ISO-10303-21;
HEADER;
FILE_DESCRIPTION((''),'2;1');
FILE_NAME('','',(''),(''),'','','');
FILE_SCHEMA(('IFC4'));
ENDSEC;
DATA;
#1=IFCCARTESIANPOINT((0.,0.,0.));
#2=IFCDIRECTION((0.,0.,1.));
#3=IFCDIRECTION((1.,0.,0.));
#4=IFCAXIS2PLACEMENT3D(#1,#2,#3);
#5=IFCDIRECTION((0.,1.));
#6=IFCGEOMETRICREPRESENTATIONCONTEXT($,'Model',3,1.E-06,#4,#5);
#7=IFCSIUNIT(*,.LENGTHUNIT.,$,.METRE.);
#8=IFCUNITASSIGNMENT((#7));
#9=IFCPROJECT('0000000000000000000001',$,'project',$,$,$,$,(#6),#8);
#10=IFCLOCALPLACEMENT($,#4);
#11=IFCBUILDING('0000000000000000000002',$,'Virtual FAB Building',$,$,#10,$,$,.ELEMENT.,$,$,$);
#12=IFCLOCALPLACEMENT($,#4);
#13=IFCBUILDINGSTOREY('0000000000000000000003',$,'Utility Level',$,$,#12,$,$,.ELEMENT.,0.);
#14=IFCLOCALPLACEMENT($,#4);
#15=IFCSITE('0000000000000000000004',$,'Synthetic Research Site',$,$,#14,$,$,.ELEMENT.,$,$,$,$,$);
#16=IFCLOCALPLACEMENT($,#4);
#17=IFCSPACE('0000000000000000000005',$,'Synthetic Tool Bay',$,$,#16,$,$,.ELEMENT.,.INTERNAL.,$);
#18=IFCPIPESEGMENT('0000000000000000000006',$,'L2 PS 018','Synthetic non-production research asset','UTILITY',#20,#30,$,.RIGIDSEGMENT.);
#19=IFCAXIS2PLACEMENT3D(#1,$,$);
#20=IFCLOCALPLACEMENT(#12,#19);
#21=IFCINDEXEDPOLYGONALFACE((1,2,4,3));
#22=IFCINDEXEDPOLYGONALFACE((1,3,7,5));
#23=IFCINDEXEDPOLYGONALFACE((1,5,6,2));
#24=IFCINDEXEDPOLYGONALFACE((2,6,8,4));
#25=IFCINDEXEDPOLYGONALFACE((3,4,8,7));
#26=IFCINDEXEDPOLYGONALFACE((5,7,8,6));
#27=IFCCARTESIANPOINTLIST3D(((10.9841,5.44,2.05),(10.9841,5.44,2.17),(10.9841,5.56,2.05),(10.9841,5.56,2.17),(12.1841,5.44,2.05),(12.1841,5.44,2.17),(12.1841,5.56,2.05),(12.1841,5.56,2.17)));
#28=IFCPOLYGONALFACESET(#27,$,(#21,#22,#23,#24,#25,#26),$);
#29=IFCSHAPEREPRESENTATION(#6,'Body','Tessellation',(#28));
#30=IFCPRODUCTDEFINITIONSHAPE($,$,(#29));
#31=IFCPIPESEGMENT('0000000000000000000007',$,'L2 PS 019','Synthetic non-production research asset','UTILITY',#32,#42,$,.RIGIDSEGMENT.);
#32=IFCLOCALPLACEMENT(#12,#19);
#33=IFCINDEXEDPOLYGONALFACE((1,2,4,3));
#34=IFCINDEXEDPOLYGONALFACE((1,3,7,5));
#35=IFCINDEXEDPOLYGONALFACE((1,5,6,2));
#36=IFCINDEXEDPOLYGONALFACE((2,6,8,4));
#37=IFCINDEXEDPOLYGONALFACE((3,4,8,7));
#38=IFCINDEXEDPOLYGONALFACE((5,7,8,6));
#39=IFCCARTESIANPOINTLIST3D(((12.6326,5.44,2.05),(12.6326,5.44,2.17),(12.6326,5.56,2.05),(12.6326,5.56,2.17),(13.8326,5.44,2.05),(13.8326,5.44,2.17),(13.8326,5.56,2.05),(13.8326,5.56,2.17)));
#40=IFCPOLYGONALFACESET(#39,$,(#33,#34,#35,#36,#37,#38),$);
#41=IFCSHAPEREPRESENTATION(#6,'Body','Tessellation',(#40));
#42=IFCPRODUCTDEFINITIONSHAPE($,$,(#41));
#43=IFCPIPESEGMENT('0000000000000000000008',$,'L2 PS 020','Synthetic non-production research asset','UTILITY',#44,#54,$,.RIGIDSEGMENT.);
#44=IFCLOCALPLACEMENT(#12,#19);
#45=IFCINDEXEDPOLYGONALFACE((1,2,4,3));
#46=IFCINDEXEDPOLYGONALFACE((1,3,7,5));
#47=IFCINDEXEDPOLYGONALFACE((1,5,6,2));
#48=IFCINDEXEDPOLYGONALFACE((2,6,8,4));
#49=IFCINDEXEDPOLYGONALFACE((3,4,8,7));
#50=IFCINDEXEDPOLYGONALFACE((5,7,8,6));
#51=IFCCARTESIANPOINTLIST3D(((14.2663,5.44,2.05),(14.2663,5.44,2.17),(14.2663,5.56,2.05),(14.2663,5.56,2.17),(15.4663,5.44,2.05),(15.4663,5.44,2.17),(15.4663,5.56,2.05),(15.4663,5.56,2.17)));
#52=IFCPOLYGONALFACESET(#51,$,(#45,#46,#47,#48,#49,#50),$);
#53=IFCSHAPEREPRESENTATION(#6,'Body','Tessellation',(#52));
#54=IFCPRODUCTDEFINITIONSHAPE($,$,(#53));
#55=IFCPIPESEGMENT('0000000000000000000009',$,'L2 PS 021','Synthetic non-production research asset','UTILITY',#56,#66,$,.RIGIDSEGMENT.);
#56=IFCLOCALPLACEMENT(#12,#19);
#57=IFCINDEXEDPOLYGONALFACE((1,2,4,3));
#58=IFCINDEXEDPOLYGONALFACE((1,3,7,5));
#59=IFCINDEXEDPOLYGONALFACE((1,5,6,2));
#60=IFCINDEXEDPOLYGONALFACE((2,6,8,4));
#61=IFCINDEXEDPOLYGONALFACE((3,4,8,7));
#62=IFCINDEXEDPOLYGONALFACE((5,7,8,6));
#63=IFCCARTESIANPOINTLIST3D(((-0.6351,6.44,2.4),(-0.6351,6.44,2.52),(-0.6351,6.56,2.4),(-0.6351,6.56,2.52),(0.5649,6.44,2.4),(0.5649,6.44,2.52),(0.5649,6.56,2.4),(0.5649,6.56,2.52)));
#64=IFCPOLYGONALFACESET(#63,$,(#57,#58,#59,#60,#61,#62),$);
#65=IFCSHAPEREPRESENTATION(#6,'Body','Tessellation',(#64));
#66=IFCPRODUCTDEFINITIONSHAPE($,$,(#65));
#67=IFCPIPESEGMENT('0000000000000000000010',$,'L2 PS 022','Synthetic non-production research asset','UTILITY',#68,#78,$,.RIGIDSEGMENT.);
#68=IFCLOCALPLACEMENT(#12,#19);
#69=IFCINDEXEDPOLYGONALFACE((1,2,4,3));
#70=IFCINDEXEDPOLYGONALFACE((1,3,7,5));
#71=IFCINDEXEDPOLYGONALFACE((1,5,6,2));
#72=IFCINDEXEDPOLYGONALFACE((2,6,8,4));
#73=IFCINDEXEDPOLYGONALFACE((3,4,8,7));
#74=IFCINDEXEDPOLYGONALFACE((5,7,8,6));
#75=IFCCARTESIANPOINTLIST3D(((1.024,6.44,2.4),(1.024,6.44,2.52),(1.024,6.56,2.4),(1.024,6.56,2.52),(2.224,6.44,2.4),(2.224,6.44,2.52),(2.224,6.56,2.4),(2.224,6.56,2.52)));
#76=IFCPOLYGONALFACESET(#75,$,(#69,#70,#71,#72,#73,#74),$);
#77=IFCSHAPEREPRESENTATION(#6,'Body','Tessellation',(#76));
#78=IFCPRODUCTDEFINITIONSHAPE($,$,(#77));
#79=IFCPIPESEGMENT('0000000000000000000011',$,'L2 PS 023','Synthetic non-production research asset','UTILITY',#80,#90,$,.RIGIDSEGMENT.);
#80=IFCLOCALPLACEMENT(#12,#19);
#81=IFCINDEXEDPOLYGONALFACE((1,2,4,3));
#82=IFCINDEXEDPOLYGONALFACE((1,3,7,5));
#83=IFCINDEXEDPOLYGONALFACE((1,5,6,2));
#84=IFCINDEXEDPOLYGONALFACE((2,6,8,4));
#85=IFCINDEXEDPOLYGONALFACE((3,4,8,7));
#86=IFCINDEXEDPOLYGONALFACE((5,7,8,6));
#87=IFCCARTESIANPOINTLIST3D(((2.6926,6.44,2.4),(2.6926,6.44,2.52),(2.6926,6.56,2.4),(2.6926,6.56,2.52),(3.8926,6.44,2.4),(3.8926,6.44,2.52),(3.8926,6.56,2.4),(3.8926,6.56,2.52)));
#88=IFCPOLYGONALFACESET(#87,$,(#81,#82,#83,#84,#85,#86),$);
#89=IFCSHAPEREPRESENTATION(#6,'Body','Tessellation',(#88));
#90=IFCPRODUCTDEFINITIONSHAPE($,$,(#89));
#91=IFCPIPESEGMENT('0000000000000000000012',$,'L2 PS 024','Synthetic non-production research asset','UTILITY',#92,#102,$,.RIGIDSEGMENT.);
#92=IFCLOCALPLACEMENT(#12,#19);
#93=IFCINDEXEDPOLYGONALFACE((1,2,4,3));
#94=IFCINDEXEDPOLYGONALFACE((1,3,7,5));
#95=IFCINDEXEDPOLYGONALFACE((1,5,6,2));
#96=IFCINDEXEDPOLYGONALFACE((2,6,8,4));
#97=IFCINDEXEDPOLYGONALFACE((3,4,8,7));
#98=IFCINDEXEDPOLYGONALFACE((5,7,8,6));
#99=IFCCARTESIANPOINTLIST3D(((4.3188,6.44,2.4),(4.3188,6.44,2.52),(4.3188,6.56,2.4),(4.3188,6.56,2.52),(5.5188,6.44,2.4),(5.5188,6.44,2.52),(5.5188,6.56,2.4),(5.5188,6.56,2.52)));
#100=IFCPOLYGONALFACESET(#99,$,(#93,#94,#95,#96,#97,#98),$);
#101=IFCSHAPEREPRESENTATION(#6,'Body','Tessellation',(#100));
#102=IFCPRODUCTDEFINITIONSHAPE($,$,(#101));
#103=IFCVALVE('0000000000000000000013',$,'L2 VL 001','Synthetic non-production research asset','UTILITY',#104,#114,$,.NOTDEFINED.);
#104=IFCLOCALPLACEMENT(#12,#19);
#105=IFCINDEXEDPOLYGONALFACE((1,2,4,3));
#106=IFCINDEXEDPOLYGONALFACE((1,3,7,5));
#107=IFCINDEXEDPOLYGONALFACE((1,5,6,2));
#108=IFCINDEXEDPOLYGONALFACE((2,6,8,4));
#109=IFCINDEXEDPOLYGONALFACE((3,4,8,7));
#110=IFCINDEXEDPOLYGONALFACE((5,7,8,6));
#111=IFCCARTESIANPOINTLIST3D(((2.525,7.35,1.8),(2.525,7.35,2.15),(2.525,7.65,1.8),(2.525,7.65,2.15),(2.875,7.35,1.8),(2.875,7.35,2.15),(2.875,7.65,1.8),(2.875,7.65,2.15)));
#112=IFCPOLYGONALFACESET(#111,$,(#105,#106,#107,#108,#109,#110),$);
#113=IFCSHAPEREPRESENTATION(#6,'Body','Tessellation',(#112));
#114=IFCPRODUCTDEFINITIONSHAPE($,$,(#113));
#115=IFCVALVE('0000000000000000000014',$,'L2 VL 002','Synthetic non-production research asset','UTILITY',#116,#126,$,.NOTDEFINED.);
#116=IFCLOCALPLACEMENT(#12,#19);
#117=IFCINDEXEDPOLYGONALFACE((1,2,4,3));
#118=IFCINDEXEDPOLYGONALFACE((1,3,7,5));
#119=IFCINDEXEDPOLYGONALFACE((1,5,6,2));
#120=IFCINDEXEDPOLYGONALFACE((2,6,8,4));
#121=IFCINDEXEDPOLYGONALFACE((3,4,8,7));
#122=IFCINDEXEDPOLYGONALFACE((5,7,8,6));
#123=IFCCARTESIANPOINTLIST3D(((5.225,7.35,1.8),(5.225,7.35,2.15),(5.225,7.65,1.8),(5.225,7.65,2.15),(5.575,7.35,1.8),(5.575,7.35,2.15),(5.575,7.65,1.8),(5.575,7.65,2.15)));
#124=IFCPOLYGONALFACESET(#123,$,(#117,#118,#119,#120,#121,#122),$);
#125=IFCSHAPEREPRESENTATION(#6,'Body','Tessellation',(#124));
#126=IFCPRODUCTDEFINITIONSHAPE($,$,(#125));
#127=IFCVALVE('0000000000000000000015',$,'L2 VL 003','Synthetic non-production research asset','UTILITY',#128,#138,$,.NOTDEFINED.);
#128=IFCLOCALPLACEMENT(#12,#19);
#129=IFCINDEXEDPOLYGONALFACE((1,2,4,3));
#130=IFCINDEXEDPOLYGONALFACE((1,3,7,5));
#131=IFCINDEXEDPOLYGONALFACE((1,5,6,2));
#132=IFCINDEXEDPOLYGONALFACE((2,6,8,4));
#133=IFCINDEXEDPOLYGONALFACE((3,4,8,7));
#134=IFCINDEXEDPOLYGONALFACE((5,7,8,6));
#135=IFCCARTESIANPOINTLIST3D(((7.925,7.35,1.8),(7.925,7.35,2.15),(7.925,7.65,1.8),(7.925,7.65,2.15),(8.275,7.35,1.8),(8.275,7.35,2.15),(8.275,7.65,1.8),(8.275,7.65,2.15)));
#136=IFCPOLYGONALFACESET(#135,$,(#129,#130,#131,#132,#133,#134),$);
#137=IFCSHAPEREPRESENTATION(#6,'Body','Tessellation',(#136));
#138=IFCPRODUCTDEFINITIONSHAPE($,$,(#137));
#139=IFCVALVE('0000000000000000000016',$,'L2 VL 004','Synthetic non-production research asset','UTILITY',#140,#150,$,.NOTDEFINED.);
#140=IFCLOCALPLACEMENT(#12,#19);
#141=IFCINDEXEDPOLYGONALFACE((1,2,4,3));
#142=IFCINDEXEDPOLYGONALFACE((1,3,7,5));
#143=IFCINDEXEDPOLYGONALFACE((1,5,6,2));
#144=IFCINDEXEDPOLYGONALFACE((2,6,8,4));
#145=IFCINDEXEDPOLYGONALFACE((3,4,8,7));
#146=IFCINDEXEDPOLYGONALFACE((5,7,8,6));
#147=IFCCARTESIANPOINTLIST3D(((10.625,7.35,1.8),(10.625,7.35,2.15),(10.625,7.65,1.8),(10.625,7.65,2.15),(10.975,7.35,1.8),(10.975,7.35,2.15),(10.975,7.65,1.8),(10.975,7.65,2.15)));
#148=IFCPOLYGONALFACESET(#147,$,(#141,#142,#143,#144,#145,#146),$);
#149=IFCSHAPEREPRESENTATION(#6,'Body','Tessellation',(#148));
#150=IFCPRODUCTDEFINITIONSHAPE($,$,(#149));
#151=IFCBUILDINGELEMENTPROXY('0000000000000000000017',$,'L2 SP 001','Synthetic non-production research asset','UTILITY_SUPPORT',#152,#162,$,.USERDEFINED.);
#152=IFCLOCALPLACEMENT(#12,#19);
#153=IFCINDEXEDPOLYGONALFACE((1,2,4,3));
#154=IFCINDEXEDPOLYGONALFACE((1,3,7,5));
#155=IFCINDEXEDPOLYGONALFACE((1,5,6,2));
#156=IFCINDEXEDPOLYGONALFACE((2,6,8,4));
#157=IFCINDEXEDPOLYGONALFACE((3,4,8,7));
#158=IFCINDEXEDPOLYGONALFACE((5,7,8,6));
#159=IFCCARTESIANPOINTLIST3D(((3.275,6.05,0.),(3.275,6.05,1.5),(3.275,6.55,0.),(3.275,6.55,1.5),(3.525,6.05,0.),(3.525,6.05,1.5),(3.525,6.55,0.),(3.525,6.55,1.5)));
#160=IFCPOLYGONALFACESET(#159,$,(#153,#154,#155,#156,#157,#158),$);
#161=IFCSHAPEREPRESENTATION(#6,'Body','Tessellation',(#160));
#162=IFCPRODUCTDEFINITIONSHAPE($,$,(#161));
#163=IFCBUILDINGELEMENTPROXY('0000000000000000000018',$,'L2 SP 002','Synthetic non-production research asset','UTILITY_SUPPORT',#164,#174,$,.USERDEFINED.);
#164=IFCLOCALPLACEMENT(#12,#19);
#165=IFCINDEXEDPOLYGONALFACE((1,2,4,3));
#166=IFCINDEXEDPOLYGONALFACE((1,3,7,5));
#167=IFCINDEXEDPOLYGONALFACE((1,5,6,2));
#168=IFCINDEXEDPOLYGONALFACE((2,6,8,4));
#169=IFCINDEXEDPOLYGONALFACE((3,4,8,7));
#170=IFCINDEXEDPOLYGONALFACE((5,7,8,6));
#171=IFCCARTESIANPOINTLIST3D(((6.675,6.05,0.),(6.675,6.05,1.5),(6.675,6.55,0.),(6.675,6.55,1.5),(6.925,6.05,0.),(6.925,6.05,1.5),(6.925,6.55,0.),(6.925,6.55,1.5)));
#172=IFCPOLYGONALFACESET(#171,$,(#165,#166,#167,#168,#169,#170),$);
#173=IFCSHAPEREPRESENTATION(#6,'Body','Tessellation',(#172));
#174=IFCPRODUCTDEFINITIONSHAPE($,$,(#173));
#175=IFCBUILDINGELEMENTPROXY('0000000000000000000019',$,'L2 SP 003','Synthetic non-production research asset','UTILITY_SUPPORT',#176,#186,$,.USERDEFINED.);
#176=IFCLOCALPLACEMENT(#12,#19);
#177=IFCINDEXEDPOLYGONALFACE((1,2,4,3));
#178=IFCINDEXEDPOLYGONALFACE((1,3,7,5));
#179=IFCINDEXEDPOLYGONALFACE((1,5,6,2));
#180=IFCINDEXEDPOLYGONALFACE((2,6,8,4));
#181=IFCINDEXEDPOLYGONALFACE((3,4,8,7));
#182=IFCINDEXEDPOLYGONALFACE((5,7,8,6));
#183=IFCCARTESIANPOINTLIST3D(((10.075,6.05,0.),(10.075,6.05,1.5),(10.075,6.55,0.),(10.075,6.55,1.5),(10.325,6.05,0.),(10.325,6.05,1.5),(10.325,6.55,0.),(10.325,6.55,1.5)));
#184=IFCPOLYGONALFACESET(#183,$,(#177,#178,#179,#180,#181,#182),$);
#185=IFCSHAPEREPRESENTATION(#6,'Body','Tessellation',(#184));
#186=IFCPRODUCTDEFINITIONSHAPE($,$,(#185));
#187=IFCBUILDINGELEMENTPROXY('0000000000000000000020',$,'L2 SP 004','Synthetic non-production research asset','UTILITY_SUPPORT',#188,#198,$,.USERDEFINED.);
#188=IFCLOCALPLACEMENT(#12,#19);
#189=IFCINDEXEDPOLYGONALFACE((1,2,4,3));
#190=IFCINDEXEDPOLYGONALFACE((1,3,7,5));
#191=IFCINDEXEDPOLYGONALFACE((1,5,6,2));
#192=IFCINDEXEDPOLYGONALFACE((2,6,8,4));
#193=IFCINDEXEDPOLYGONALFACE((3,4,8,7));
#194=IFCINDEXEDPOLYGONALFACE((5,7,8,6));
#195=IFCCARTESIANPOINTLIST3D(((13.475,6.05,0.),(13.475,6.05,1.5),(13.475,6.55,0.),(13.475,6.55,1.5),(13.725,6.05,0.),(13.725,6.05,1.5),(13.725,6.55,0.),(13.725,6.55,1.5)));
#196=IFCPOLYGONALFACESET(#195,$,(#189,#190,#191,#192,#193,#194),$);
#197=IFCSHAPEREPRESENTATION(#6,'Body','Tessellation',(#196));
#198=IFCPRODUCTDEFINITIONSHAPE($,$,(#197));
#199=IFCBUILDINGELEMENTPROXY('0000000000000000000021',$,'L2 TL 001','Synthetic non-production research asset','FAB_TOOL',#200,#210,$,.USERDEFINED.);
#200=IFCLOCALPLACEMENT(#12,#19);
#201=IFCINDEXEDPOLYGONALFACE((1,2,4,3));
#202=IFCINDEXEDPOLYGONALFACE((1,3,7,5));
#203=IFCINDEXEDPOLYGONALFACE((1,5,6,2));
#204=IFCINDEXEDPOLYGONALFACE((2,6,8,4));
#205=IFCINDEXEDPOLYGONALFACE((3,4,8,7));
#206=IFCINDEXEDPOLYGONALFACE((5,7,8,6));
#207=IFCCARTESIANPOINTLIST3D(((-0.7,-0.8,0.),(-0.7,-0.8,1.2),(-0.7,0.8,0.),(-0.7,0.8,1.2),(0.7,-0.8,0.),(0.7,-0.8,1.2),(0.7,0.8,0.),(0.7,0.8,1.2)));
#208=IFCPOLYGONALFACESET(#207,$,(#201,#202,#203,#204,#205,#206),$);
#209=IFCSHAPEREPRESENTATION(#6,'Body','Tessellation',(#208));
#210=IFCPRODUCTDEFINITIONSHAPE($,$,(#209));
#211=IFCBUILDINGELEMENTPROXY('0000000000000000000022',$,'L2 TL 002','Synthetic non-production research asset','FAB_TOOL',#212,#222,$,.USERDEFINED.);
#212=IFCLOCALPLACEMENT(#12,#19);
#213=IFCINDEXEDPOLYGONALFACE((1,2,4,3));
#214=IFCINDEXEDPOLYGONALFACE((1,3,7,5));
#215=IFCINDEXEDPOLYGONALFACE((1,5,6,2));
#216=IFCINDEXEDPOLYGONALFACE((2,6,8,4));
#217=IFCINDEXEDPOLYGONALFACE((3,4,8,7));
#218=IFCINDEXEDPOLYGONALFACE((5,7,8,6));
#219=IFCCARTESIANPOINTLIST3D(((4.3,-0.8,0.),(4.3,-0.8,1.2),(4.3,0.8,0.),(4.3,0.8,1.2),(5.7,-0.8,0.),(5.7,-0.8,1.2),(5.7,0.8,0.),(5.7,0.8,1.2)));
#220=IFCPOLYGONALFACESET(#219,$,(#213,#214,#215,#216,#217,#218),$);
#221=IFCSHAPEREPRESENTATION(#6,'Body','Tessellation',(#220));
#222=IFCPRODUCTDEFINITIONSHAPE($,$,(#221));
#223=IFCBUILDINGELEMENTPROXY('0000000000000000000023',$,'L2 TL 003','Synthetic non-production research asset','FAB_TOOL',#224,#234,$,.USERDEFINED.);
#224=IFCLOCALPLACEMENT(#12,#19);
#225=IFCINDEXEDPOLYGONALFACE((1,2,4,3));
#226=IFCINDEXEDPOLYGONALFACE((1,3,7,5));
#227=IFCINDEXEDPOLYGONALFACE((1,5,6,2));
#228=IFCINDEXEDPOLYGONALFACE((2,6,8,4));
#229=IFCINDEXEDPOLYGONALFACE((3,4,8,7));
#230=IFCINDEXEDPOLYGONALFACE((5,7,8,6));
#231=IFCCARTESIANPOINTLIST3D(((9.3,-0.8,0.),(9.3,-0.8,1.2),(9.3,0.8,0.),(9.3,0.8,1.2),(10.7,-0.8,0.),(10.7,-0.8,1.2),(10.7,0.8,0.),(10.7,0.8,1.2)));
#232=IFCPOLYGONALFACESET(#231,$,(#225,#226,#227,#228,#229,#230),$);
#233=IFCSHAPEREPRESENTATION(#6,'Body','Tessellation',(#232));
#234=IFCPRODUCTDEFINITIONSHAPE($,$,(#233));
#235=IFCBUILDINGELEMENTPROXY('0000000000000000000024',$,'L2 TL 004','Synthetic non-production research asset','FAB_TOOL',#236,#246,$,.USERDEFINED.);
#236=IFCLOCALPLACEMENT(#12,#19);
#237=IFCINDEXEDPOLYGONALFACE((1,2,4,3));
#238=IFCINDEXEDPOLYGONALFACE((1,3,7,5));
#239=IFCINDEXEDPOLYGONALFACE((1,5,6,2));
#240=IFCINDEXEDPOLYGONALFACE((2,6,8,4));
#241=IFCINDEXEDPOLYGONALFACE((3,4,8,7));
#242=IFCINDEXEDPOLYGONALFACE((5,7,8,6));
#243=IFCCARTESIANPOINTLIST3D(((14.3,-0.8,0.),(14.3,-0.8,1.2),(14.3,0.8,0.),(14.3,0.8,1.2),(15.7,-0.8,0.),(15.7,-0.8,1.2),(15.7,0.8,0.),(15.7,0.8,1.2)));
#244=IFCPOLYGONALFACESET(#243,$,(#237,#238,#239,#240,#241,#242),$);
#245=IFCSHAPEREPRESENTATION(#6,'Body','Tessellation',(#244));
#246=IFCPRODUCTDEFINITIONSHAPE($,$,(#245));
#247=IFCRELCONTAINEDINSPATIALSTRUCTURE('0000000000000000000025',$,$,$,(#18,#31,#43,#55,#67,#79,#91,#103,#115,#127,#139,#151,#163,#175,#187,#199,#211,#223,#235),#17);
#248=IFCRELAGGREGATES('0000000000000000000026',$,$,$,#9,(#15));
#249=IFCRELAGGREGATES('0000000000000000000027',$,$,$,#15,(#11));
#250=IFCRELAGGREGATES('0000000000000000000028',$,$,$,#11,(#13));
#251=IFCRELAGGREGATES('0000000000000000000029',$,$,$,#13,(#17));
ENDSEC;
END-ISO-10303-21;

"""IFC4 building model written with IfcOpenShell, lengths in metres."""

from ifc_helpers import new_model, si_unit, direction, frame, origin_with_axes, origin_2d_with_axis, place, context, project, spatial, rectangle, extrude, element, save


model = new_model("IFC4")

# Units and contexts
model_context = context("Model", 3, precision=1e-06, world=origin_with_axes(), true_north=direction((0.0, 1.0)))
ifc_project = project(units=[si_unit("LENGTHUNIT", "METRE")], contexts=[model_context])

# Site, building, storey, space
site_placement = place(None, origin_with_axes())
site = spatial("IfcSite", under=ifc_project, at=site_placement, Name="Synthetic Research Site", CompositionType="ELEMENT")
building_placement = place(None, origin_with_axes())
building = spatial("IfcBuilding", under=site, at=building_placement, Name="Virtual FAB Building", CompositionType="ELEMENT")
storey_placement = place(None, origin_with_axes())
storey = spatial("IfcBuildingStorey", under=building, at=storey_placement, Name="Utility Level", CompositionType="ELEMENT", Elevation=0.0)
space_placement = place(None, origin_with_axes())
space = spatial("IfcSpace", under=storey, at=space_placement, Name="Synthetic Tool Bay", CompositionType="ELEMENT", PredefinedType="INTERNAL")

# Pipe segments
for number, where, z_axis, x_axis, name in (
    (1, (11.5841, 5.5, 2.05), (0.0, 0.0, 1.0), (1.0, 0.0, 0.0), "L2 PS 018"),
    (2, (13.2326, 5.5, 2.05), (0.0, 0.0, 1.0), (1.0, 0.0, 0.0), "L2 PS 019"),
    (3, (14.8663, 5.5, 2.05), (0.0, 0.0, 1.0), (1.0, 0.0, 0.0), "L2 PS 020"),
    (4, (-0.0351, 6.5, 2.4), (0.0, 0.0, 1.0), (1.0, 0.0, 0.0), "L2 PS 021"),
    (5, (1.624, 6.5, 2.4), (0.0, 0.0, 1.0), (1.0, 0.0, 0.0), "L2 PS 022"),
    (6, (3.2926, 6.5, 2.4), (0.0, 0.0, 1.0), (1.0, 0.0, 0.0), "L2 PS 023"),
    (7, (4.9188, 6.5, 2.4), (0.0, 0.0, 1.0), (1.0, 0.0, 0.0), "L2 PS 024"),
):
    element("IfcPipeSegment", number, at=place(None, frame(where, z_axis=z_axis, x_axis=x_axis)), inside=space, Name=name, Description="Synthetic non-production research asset", ObjectType="UTILITY", PredefinedType="RIGIDSEGMENT", context=model_context, shape_type="SweptSolid", body=[
        extrude(rectangle(XDim=1.2, YDim=0.12, at=origin_2d_with_axis()), origin_with_axes(), (0.0, 0.0, 1.0), 0.12),
    ])

# Valves
for number, where, z_axis, x_axis, name in (
    (8, (2.7, 7.5, 1.8), (0.0, 0.0, 1.0), (1.0, 0.0, 0.0), "L2 VL 001"),
    (9, (5.4, 7.5, 1.8), (0.0, 0.0, 1.0), (1.0, 0.0, 0.0), "L2 VL 002"),
    (10, (8.1, 7.5, 1.8), (0.0, 0.0, 1.0), (1.0, 0.0, 0.0), "L2 VL 003"),
    (11, (10.8, 7.5, 1.8), (0.0, 0.0, 1.0), (1.0, 0.0, 0.0), "L2 VL 004"),
):
    element("IfcValve", number, at=place(None, frame(where, z_axis=z_axis, x_axis=x_axis)), inside=space, Name=name, Description="Synthetic non-production research asset", ObjectType="UTILITY", PredefinedType="NOTDEFINED", context=model_context, shape_type="SweptSolid", body=[
        extrude(rectangle(XDim=0.35, YDim=0.3, at=origin_2d_with_axis()), origin_with_axes(), (0.0, 0.0, 1.0), 0.35),
    ])

# Building element proxies
for number, where, z_axis, x_axis, name in (
    (12, (3.4, 6.3, 0.0), (0.0, 0.0, 1.0), (1.0, 0.0, 0.0), "L2 SP 001"),
    (13, (6.8, 6.3, 0.0), (0.0, 0.0, 1.0), (1.0, 0.0, 0.0), "L2 SP 002"),
    (14, (10.2, 6.3, 0.0), (0.0, 0.0, 1.0), (1.0, 0.0, 0.0), "L2 SP 003"),
    (15, (13.6, 6.3, 0.0), (0.0, 0.0, 1.0), (1.0, 0.0, 0.0), "L2 SP 004"),
):
    element("IfcBuildingElementProxy", number, at=place(None, frame(where, z_axis=z_axis, x_axis=x_axis)), inside=space, Name=name, Description="Synthetic non-production research asset", ObjectType="UTILITY_SUPPORT", PredefinedType="USERDEFINED", context=model_context, shape_type="SweptSolid", body=[
        extrude(rectangle(XDim=0.25, YDim=0.5, at=origin_2d_with_axis()), origin_with_axes(), (0.0, 0.0, 1.0), 1.5),
    ])
for number, where, z_axis, x_axis, name in (
    (16, (0.0, 0.0, 0.0), (0.0, 0.0, 1.0), (1.0, 0.0, 0.0), "L2 TL 001"),
    (17, (5.0, 0.0, 0.0), (0.0, 0.0, 1.0), (1.0, 0.0, 0.0), "L2 TL 002"),
    (18, (10.0, 0.0, 0.0), (0.0, 0.0, 1.0), (1.0, 0.0, 0.0), "L2 TL 003"),
    (19, (15.0, 0.0, 0.0), (0.0, 0.0, 1.0), (1.0, 0.0, 0.0), "L2 TL 004"),
):
    element("IfcBuildingElementProxy", number, at=place(None, frame(where, z_axis=z_axis, x_axis=x_axis)), inside=space, Name=name, Description="Synthetic non-production research asset", ObjectType="FAB_TOOL", PredefinedType="USERDEFINED", context=model_context, shape_type="SweptSolid", body=[
        extrude(rectangle(XDim=1.4, YDim=1.6, at=origin_2d_with_axis()), origin_with_axes(), (0.0, 0.0, 1.0), 1.2),
    ])

save(model, "model.ifc")
